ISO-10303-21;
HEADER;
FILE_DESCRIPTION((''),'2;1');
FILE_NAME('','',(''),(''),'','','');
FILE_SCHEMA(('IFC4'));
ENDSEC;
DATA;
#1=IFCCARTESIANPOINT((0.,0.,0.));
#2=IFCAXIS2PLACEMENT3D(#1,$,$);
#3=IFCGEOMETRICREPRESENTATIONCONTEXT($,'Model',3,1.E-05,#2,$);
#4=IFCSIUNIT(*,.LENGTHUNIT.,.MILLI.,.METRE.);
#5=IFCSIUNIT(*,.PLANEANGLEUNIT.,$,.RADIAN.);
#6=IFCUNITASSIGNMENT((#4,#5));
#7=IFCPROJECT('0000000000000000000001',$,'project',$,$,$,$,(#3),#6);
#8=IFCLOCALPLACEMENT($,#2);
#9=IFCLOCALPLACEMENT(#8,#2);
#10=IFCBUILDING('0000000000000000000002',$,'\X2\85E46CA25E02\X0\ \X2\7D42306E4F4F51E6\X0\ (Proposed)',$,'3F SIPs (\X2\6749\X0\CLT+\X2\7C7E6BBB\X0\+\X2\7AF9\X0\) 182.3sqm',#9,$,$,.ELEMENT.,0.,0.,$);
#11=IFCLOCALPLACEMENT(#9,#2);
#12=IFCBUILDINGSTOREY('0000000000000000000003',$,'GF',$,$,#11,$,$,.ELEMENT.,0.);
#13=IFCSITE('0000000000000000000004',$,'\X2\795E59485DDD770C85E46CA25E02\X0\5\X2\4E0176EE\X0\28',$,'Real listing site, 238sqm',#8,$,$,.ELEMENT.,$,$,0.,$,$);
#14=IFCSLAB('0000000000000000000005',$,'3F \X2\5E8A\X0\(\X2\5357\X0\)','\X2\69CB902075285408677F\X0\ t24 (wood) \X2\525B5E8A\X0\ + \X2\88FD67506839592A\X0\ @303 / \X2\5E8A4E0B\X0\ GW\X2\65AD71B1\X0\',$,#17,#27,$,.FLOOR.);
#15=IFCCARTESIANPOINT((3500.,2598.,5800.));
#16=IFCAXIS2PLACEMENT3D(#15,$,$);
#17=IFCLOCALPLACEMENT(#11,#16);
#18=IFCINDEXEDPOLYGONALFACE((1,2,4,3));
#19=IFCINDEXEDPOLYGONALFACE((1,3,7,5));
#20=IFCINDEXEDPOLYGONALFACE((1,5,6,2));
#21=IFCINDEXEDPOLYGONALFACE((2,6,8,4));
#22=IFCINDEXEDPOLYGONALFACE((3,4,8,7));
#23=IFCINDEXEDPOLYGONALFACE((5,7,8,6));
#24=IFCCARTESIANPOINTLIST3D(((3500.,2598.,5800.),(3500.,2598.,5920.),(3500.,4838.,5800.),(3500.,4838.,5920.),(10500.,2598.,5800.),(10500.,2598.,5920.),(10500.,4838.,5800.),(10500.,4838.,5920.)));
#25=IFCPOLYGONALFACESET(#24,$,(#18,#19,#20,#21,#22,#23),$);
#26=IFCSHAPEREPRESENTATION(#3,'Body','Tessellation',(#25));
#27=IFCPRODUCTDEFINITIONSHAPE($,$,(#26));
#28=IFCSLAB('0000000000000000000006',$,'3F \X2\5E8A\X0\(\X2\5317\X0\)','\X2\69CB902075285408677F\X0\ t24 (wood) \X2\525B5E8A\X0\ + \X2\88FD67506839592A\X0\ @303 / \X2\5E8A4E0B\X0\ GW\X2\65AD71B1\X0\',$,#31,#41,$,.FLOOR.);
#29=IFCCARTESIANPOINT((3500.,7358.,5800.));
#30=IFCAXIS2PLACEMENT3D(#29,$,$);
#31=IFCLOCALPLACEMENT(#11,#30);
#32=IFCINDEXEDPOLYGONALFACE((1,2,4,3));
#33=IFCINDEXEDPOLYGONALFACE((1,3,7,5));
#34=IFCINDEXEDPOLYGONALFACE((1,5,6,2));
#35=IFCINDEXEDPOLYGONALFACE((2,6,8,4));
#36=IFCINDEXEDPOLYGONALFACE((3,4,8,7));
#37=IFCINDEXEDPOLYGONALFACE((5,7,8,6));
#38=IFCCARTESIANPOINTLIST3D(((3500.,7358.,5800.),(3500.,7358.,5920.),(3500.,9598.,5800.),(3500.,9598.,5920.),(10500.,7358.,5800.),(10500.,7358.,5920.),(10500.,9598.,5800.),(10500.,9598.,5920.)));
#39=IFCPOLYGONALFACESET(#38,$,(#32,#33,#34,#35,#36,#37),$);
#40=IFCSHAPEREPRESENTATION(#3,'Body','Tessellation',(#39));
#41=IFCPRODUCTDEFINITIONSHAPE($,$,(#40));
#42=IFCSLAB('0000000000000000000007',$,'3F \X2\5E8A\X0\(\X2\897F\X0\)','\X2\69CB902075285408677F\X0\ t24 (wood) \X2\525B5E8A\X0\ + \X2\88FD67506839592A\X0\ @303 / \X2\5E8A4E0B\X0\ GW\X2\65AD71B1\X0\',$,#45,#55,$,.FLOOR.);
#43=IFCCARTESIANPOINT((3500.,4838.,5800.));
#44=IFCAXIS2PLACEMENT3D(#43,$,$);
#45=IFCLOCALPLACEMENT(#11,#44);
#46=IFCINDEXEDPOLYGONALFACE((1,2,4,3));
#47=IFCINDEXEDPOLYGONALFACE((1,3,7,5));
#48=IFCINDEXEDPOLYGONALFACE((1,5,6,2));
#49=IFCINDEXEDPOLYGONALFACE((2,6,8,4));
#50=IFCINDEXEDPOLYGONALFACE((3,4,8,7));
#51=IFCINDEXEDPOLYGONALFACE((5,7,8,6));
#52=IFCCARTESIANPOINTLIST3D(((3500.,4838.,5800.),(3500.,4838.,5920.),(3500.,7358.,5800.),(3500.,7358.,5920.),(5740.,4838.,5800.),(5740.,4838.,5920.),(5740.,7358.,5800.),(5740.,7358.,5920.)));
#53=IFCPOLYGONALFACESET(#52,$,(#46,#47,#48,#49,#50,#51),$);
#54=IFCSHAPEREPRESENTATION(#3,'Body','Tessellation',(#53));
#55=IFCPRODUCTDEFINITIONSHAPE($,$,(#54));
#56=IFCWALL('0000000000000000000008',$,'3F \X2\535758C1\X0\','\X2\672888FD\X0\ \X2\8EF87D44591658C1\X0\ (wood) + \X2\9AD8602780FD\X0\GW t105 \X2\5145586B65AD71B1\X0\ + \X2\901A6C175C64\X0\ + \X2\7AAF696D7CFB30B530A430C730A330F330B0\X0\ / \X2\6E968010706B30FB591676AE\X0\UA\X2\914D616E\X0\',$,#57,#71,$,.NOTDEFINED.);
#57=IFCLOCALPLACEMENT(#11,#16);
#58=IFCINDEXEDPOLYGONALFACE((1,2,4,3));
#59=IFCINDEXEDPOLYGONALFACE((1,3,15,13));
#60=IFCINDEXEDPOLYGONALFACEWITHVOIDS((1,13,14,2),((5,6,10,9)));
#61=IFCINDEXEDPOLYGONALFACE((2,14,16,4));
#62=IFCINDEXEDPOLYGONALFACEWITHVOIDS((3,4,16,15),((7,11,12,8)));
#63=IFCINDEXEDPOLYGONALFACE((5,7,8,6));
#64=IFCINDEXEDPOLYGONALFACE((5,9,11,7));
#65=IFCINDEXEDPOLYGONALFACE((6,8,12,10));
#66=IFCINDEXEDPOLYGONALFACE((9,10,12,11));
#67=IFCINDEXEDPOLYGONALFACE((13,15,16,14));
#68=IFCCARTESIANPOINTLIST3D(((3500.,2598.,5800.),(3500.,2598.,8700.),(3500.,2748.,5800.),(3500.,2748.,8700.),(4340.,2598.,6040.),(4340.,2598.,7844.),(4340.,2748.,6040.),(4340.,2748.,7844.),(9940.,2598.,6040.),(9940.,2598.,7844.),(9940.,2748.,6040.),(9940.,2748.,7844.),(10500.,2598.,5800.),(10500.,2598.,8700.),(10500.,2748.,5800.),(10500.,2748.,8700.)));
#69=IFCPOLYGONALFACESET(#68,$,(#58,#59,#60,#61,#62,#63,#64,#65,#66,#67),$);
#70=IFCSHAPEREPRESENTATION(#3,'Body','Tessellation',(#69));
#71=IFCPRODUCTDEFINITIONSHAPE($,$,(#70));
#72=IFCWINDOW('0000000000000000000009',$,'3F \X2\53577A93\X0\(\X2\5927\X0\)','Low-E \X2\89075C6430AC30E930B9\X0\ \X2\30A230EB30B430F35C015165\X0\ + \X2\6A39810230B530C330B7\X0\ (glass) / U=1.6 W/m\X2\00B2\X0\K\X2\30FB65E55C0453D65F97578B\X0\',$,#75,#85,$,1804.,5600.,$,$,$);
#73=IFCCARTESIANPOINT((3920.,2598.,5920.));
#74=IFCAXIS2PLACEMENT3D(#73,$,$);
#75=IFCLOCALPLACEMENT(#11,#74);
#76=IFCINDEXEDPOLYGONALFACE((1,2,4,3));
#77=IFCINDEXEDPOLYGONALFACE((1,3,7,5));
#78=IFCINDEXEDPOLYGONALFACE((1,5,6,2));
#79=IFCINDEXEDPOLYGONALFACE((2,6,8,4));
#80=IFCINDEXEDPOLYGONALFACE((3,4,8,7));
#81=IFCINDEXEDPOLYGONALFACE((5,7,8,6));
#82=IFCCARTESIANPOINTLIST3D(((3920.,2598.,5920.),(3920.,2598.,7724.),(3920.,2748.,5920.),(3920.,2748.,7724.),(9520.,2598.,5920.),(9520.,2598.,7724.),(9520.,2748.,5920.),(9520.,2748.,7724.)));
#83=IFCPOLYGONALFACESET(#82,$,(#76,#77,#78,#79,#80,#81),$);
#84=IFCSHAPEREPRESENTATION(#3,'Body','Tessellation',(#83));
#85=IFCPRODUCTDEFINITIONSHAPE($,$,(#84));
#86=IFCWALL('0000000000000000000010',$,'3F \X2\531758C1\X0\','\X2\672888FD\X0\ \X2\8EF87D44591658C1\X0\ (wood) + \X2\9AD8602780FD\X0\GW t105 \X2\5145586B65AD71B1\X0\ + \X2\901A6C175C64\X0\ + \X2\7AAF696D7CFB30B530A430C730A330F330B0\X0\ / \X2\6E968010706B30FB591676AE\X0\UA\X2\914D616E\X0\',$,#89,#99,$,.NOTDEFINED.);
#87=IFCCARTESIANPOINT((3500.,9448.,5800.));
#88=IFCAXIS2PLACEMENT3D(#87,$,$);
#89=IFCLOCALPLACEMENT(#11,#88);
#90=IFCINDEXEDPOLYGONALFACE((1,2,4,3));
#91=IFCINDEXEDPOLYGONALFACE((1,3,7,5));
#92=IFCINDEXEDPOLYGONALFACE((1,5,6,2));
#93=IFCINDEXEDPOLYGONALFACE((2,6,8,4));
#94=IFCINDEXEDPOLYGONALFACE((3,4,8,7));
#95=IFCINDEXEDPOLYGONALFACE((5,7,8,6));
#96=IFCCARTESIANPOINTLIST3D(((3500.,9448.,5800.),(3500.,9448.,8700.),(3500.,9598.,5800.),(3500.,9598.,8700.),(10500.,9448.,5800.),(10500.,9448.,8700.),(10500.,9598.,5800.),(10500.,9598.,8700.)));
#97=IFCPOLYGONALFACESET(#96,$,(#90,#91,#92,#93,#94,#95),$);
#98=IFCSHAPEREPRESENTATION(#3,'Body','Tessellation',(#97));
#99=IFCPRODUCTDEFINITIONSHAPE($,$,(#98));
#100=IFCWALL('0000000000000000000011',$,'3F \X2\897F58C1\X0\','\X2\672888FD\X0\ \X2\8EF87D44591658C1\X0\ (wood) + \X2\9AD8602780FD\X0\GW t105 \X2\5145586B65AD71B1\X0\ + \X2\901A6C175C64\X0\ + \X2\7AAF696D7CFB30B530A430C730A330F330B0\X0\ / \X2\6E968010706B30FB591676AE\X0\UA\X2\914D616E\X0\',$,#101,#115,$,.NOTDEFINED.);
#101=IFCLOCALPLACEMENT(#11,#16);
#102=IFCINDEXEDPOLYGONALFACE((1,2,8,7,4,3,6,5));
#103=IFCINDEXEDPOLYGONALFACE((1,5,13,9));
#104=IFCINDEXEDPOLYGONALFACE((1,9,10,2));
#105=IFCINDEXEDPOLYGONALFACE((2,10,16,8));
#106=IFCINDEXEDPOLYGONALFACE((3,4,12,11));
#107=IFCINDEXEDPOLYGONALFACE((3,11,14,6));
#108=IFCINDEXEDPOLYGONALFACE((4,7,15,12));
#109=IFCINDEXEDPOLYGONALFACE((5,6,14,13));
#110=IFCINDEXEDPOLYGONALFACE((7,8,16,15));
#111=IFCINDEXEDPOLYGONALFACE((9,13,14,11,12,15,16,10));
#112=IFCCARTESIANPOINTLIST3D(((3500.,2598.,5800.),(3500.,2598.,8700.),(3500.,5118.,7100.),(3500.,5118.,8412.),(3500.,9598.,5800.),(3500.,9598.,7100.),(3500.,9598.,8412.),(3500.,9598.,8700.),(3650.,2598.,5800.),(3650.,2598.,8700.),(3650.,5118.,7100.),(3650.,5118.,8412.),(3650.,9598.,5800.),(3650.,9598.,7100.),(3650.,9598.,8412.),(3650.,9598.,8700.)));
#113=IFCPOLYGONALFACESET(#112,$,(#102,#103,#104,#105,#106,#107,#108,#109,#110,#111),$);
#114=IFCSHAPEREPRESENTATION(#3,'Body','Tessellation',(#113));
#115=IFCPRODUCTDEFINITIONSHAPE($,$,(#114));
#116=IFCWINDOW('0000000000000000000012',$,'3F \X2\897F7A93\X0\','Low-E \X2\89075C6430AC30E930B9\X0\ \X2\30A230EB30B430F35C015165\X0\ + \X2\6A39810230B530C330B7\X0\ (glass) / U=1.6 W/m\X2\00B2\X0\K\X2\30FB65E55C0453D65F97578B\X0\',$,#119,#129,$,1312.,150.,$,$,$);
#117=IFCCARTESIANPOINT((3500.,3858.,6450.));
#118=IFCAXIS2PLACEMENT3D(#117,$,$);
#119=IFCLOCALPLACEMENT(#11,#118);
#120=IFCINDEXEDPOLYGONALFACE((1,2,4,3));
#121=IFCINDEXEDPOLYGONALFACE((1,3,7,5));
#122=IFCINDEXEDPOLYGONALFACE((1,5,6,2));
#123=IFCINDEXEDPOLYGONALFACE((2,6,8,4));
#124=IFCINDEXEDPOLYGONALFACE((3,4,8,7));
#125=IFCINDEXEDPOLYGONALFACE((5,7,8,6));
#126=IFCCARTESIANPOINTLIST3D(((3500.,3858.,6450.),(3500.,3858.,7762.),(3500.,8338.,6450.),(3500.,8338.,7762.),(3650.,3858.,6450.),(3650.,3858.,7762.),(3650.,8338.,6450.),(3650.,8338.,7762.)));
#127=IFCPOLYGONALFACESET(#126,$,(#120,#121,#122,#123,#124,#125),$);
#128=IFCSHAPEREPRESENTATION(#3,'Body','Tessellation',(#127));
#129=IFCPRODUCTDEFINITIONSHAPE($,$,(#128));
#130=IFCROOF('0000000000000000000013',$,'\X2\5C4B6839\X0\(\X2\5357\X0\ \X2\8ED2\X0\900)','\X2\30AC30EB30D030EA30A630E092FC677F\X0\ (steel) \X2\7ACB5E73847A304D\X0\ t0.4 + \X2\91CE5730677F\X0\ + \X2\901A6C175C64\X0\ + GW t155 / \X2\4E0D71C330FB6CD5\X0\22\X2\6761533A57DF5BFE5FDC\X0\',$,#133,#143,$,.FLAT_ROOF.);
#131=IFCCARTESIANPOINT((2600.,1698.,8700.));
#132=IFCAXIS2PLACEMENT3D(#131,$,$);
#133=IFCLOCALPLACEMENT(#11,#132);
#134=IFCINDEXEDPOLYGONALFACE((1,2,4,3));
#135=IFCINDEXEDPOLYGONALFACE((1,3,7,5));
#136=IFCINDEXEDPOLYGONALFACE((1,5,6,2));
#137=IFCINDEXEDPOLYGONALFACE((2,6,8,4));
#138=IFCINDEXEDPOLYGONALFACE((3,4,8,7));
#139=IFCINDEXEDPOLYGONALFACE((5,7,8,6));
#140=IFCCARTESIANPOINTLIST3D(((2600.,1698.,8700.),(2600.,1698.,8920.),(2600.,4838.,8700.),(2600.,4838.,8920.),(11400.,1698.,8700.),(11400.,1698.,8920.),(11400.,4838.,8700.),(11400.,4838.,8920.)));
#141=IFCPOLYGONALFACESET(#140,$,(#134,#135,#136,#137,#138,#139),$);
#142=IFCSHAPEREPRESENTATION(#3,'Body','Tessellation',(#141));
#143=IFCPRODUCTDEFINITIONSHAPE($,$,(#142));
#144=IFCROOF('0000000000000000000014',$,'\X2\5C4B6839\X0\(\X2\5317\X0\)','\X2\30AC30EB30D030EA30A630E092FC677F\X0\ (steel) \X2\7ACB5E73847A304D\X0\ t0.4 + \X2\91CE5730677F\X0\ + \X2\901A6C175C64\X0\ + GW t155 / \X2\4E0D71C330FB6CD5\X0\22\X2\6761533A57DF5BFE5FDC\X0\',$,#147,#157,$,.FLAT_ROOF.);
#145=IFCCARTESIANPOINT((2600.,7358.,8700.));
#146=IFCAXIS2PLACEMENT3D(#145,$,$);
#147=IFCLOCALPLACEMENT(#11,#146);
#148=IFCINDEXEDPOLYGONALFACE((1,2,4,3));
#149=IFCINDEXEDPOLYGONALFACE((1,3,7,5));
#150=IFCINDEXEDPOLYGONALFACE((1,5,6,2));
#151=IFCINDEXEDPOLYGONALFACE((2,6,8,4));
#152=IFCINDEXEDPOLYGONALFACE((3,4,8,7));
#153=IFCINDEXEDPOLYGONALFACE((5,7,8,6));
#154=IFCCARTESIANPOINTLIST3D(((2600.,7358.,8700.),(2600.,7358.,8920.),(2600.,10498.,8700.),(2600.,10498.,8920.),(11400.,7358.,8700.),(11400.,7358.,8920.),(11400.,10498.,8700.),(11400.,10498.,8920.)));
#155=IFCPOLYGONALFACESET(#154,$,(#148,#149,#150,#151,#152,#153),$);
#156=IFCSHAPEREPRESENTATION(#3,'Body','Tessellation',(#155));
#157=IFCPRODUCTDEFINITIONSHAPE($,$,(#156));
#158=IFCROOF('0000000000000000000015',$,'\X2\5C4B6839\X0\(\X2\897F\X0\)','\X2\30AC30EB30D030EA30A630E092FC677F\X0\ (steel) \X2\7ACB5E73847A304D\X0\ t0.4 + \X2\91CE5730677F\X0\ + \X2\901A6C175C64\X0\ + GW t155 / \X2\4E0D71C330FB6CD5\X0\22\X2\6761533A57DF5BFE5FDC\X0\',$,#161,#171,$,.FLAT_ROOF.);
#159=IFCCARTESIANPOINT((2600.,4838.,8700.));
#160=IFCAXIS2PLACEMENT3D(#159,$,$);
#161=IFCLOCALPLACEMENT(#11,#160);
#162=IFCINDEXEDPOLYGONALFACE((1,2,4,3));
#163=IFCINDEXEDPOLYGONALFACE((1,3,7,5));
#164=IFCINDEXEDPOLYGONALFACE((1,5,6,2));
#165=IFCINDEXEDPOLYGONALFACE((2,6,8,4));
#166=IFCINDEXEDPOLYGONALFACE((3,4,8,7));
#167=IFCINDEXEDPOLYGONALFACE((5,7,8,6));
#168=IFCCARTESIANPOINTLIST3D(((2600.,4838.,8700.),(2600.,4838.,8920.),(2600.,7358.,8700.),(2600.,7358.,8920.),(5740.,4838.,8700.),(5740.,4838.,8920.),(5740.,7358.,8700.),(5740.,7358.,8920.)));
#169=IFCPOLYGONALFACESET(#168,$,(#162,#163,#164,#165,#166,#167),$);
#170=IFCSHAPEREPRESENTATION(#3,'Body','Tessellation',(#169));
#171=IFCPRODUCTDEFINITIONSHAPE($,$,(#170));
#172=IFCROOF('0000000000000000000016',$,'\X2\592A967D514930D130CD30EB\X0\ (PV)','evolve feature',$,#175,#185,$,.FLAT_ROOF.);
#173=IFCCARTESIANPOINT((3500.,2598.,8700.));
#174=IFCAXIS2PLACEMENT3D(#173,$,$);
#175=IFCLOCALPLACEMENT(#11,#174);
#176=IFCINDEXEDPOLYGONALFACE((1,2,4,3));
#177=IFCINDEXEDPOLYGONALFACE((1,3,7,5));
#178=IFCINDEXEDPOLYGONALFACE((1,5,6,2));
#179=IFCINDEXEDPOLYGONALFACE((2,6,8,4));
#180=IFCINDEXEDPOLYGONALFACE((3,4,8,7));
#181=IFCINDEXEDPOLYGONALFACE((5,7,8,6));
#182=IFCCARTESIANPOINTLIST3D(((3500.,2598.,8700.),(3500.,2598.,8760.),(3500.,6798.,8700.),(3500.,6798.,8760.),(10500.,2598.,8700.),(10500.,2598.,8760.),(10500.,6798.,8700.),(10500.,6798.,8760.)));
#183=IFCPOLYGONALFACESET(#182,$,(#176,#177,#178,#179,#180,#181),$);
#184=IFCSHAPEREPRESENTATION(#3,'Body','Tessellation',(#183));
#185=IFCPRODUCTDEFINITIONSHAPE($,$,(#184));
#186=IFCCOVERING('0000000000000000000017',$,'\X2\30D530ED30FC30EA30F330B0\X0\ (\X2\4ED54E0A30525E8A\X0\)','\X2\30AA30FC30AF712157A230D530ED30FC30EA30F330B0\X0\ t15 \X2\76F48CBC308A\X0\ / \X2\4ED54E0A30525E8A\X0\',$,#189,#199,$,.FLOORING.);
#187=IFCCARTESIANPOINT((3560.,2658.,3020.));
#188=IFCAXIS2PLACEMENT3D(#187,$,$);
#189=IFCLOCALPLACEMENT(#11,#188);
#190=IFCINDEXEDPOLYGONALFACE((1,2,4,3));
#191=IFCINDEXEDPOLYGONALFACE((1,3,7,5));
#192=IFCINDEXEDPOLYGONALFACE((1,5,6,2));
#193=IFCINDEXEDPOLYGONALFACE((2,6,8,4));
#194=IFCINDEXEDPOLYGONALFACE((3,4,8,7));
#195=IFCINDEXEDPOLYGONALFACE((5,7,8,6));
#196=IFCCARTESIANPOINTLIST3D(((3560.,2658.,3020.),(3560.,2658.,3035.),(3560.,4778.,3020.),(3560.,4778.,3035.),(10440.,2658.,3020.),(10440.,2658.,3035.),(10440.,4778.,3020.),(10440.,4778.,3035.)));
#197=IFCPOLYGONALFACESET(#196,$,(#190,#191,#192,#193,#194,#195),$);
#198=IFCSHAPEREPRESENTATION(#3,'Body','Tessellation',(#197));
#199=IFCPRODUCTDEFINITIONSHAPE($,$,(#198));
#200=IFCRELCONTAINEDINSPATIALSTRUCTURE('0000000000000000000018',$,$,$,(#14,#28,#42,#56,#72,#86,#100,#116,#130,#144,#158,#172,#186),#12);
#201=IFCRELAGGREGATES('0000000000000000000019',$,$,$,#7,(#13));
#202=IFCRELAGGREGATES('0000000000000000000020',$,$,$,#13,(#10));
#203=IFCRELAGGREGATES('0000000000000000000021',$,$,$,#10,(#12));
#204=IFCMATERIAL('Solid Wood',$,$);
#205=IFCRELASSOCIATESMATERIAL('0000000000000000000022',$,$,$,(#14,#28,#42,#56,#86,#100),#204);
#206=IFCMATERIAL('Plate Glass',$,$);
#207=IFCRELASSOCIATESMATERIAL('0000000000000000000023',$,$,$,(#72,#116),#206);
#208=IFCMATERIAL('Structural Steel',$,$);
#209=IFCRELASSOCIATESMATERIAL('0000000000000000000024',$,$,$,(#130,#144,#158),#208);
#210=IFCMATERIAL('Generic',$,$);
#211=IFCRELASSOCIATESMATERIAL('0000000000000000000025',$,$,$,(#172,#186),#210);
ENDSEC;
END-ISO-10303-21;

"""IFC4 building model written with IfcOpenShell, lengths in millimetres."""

from ifc_helpers import new_model, si_unit, frame, frame_2d, origin, place, context, project, spatial, rectangle, extrude, material, element, fill, save


model = new_model("IFC4")

# Units and contexts
model_context = context("Model", 3, precision=1e-05, world=origin())
ifc_project = project(units=[si_unit("LENGTHUNIT", "METRE", prefix="MILLI"), si_unit("PLANEANGLEUNIT", "RADIAN")], contexts=[model_context])

# Site, building, storey
site_placement = place(None, origin())
site = spatial("IfcSite", under=ifc_project, at=site_placement, Name="神奈川県藤沢市5丁目28", ObjectType="Real listing site, 238sqm", CompositionType="ELEMENT", RefElevation=0.0)
building_placement = place(site_placement, origin())
building = spatial("IfcBuilding", under=site, at=building_placement, Name="藤沢市 終の住処 (Proposed)", ObjectType="3F SIPs (杉CLT+籾殻+竹) 182.3sqm", CompositionType="ELEMENT", ElevationOfRefHeight=0.0, ElevationOfTerrain=0.0)
storey_placement = place(building_placement, origin())
storey = spatial("IfcBuildingStorey", under=building, at=storey_placement, Name="GF", CompositionType="ELEMENT", Elevation=0.0)

# Slabs
ifc_material_1 = material(Name="Solid Wood")
slab_1_placement = place(storey_placement, frame((3500.0, 2598.0, 5800.0)))
element("IfcSlab", 1, at=slab_1_placement, inside=storey, material=ifc_material_1, Name="3F 床(南)", Description="構造用合板 t24 (wood) 剛床 + 製材根太 @303 / 床下 GW断熱", PredefinedType="FLOOR", context=model_context, shape_type="SweptSolid", body=[
    extrude(rectangle(XDim=7000.0, YDim=2240.0, at=frame_2d((3500.0, 1120.0))), frame((3500.0, 2598.0, 5800.0)), (0.0, 0.0, 1.0), 120.0),
])
slab_2_placement = place(storey_placement, frame((3500.0, 7358.0, 5800.0)))
element("IfcSlab", 2, at=slab_2_placement, inside=storey, material=ifc_material_1, Name="3F 床(北)", Description="構造用合板 t24 (wood) 剛床 + 製材根太 @303 / 床下 GW断熱", PredefinedType="FLOOR", context=model_context, shape_type="SweptSolid", body=[
    extrude(rectangle(XDim=7000.0, YDim=2240.0, at=frame_2d((3500.0, 1120.0))), frame((3500.0, 7358.0, 5800.0)), (0.0, 0.0, 1.0), 120.0),
])
slab_3_placement = place(storey_placement, frame((3500.0, 4838.0, 5800.0)))
element("IfcSlab", 3, at=slab_3_placement, inside=storey, material=ifc_material_1, Name="3F 床(西)", Description="構造用合板 t24 (wood) 剛床 + 製材根太 @303 / 床下 GW断熱", PredefinedType="FLOOR", context=model_context, shape_type="SweptSolid", body=[
    extrude(rectangle(XDim=2240.0, YDim=2520.0, at=frame_2d((1120.0, 1260.0))), frame((3500.0, 4838.0, 5800.0)), (0.0, 0.0, 1.0), 120.0),
])

# Wall, opening, window
wall_1_placement = place(storey_placement, frame((3500.0, 2598.0, 5800.0)))
wall_1 = element("IfcWall", 4, at=wall_1_placement, inside=storey, material=ifc_material_1, Name="3F 南壁", Description="木製 軸組外壁 (wood) + 高性能GW t105 充填断熱 + 通気層 + 窯業系サイディング / 準耐火・外皮UA配慮", PredefinedType="NOTDEFINED", context=model_context, shape_type="SweptSolid", body=[
    extrude(rectangle(XDim=7000.0, YDim=150.0, at=frame_2d((3500.0, 75.0))), frame((3500.0, 2598.0, 5800.0)), (0.0, 0.0, 1.0), 2900.0),
])
opening_1_placement = place(storey_placement, frame((3920.0, 2598.0, 5920.0)))
opening_1 = element("IfcOpeningElement", 5, at=opening_1_placement, cuts=wall_1, PredefinedType="NOTDEFINED", context=model_context, shape_type="SweptSolid", body=[
    extrude(rectangle(XDim=5600.0, YDim=150.0, at=frame_2d((2800.0, 75.0))), frame((3920.0, 2598.0, 5920.0)), (0.0, 0.0, 1.0), 1804.0),
])
ifc_material_2 = material(Name="Plate Glass")
window_1_placement = place(storey_placement, frame((3920.0, 2598.0, 5920.0)))
window_1 = element("IfcWindow", 6, at=window_1_placement, inside=storey, material=ifc_material_2, Name="3F 南窓(大)", Description="Low-E 複層ガラス アルゴン封入 + 樹脂サッシ (glass) / U=1.6 W/m²K・日射取得型", OverallHeight=1804.0, OverallWidth=5600.0, context=model_context, shape_type="SweptSolid", body=[
    extrude(rectangle(XDim=5600.0, YDim=150.0, at=frame_2d((2800.0, 75.0))), frame((3920.0, 2598.0, 5920.0)), (0.0, 0.0, 1.0), 1804.0),
])
fill(opening_1, window_1)

# Wall
wall_2_placement = place(storey_placement, frame((3500.0, 9448.0, 5800.0)))
element("IfcWall", 7, at=wall_2_placement, inside=storey, material=ifc_material_1, Name="3F 北壁", Description="木製 軸組外壁 (wood) + 高性能GW t105 充填断熱 + 通気層 + 窯業系サイディング / 準耐火・外皮UA配慮", PredefinedType="NOTDEFINED", context=model_context, shape_type="SweptSolid", body=[
    extrude(rectangle(XDim=7000.0, YDim=150.0, at=frame_2d((3500.0, 75.0))), frame((3500.0, 9448.0, 5800.0)), (0.0, 0.0, 1.0), 2900.0),
])

# Wall, opening, window
wall_3_placement = place(storey_placement, frame((3500.0, 2598.0, 5800.0)))
wall_3 = element("IfcWall", 8, at=wall_3_placement, inside=storey, material=ifc_material_1, Name="3F 西壁", Description="木製 軸組外壁 (wood) + 高性能GW t105 充填断熱 + 通気層 + 窯業系サイディング / 準耐火・外皮UA配慮", PredefinedType="NOTDEFINED", context=model_context, shape_type="SweptSolid", body=[
    extrude(rectangle(XDim=150.0, YDim=7000.0, at=frame_2d((75.0, 3500.0))), frame((3500.0, 2598.0, 5800.0)), (0.0, 0.0, 1.0), 2900.0),
])
opening_2_placement = place(storey_placement, frame((3500.0, 3858.0, 6450.0)))
opening_2 = element("IfcOpeningElement", 9, at=opening_2_placement, cuts=wall_3, PredefinedType="NOTDEFINED", context=model_context, shape_type="SweptSolid", body=[
    extrude(rectangle(XDim=150.0, YDim=4480.0, at=frame_2d((75.0, 2240.0))), frame((3500.0, 3858.0, 6450.0)), (0.0, 0.0, 1.0), 1312.0),
])
window_2_placement = place(storey_placement, frame((3500.0, 3858.0, 6450.0)))
window_2 = element("IfcWindow", 10, at=window_2_placement, inside=storey, material=ifc_material_2, Name="3F 西窓", Description="Low-E 複層ガラス アルゴン封入 + 樹脂サッシ (glass) / U=1.6 W/m²K・日射取得型", OverallHeight=1312.0, OverallWidth=150.0, context=model_context, shape_type="SweptSolid", body=[
    extrude(rectangle(XDim=150.0, YDim=4480.0, at=frame_2d((75.0, 2240.0))), frame((3500.0, 3858.0, 6450.0)), (0.0, 0.0, 1.0), 1312.0),
])
fill(opening_2, window_2)

# Roofs
ifc_material_3 = material(Name="Structural Steel")
roof_1_placement = place(storey_placement, frame((2600.0, 1698.0, 8700.0)))
element("IfcRoof", 11, at=roof_1_placement, inside=storey, material=ifc_material_3, Name="屋根(南 軒900)", Description="ガルバリウム鋼板 (steel) 立平葺き t0.4 + 野地板 + 通気層 + GW t155 / 不燃・法22条区域対応", PredefinedType="FLAT_ROOF", context=model_context, shape_type="SweptSolid", body=[
    extrude(rectangle(XDim=8800.0, YDim=3140.0, at=frame_2d((4400.0, 1570.0))), frame((2600.0, 1698.0, 8700.0)), (0.0, 0.0, 1.0), 220.0),
])
roof_2_placement = place(storey_placement, frame((2600.0, 7358.0, 8700.0)))
element("IfcRoof", 12, at=roof_2_placement, inside=storey, material=ifc_material_3, Name="屋根(北)", Description="ガルバリウム鋼板 (steel) 立平葺き t0.4 + 野地板 + 通気層 + GW t155 / 不燃・法22条区域対応", PredefinedType="FLAT_ROOF", context=model_context, shape_type="SweptSolid", body=[
    extrude(rectangle(XDim=8800.0, YDim=3140.0, at=frame_2d((4400.0, 1570.0))), frame((2600.0, 7358.0, 8700.0)), (0.0, 0.0, 1.0), 220.0),
])
roof_3_placement = place(storey_placement, frame((2600.0, 4838.0, 8700.0)))
element("IfcRoof", 13, at=roof_3_placement, inside=storey, material=ifc_material_3, Name="屋根(西)", Description="ガルバリウム鋼板 (steel) 立平葺き t0.4 + 野地板 + 通気層 + GW t155 / 不燃・法22条区域対応", PredefinedType="FLAT_ROOF", context=model_context, shape_type="SweptSolid", body=[
    extrude(rectangle(XDim=3140.0, YDim=2520.0, at=frame_2d((1570.0, 1260.0))), frame((2600.0, 4838.0, 8700.0)), (0.0, 0.0, 1.0), 220.0),
])
ifc_material_4 = material(Name="Generic")
roof_4_placement = place(storey_placement, frame((3500.0, 2598.0, 8700.0)))
element("IfcRoof", 14, at=roof_4_placement, inside=storey, material=ifc_material_4, Name="太陽光パネル (PV)", Description="evolve feature", PredefinedType="FLAT_ROOF", context=model_context, shape_type="SweptSolid", body=[
    extrude(rectangle(XDim=7000.0, YDim=4200.0, at=frame_2d((3500.0, 2100.0))), frame((3500.0, 2598.0, 8700.0)), (0.0, 0.0, 1.0), 60.0),
])

# Covering
covering_1_placement = place(storey_placement, frame((3560.0, 2658.0, 3020.0)))
element("IfcCovering", 15, at=covering_1_placement, inside=storey, material=ifc_material_4, Name="フローリング (仕上げ床)", Description="オーク無垢フローリング t15 直貼り / 仕上げ床", PredefinedType="FLOORING", context=model_context, shape_type="SweptSolid", body=[
    extrude(rectangle(XDim=6880.0, YDim=2120.0, at=frame_2d((3440.0, 1060.0))), frame((3560.0, 2658.0, 3020.0)), (0.0, 0.0, 1.0), 15.0),
])

save(model, "model.ifc")
